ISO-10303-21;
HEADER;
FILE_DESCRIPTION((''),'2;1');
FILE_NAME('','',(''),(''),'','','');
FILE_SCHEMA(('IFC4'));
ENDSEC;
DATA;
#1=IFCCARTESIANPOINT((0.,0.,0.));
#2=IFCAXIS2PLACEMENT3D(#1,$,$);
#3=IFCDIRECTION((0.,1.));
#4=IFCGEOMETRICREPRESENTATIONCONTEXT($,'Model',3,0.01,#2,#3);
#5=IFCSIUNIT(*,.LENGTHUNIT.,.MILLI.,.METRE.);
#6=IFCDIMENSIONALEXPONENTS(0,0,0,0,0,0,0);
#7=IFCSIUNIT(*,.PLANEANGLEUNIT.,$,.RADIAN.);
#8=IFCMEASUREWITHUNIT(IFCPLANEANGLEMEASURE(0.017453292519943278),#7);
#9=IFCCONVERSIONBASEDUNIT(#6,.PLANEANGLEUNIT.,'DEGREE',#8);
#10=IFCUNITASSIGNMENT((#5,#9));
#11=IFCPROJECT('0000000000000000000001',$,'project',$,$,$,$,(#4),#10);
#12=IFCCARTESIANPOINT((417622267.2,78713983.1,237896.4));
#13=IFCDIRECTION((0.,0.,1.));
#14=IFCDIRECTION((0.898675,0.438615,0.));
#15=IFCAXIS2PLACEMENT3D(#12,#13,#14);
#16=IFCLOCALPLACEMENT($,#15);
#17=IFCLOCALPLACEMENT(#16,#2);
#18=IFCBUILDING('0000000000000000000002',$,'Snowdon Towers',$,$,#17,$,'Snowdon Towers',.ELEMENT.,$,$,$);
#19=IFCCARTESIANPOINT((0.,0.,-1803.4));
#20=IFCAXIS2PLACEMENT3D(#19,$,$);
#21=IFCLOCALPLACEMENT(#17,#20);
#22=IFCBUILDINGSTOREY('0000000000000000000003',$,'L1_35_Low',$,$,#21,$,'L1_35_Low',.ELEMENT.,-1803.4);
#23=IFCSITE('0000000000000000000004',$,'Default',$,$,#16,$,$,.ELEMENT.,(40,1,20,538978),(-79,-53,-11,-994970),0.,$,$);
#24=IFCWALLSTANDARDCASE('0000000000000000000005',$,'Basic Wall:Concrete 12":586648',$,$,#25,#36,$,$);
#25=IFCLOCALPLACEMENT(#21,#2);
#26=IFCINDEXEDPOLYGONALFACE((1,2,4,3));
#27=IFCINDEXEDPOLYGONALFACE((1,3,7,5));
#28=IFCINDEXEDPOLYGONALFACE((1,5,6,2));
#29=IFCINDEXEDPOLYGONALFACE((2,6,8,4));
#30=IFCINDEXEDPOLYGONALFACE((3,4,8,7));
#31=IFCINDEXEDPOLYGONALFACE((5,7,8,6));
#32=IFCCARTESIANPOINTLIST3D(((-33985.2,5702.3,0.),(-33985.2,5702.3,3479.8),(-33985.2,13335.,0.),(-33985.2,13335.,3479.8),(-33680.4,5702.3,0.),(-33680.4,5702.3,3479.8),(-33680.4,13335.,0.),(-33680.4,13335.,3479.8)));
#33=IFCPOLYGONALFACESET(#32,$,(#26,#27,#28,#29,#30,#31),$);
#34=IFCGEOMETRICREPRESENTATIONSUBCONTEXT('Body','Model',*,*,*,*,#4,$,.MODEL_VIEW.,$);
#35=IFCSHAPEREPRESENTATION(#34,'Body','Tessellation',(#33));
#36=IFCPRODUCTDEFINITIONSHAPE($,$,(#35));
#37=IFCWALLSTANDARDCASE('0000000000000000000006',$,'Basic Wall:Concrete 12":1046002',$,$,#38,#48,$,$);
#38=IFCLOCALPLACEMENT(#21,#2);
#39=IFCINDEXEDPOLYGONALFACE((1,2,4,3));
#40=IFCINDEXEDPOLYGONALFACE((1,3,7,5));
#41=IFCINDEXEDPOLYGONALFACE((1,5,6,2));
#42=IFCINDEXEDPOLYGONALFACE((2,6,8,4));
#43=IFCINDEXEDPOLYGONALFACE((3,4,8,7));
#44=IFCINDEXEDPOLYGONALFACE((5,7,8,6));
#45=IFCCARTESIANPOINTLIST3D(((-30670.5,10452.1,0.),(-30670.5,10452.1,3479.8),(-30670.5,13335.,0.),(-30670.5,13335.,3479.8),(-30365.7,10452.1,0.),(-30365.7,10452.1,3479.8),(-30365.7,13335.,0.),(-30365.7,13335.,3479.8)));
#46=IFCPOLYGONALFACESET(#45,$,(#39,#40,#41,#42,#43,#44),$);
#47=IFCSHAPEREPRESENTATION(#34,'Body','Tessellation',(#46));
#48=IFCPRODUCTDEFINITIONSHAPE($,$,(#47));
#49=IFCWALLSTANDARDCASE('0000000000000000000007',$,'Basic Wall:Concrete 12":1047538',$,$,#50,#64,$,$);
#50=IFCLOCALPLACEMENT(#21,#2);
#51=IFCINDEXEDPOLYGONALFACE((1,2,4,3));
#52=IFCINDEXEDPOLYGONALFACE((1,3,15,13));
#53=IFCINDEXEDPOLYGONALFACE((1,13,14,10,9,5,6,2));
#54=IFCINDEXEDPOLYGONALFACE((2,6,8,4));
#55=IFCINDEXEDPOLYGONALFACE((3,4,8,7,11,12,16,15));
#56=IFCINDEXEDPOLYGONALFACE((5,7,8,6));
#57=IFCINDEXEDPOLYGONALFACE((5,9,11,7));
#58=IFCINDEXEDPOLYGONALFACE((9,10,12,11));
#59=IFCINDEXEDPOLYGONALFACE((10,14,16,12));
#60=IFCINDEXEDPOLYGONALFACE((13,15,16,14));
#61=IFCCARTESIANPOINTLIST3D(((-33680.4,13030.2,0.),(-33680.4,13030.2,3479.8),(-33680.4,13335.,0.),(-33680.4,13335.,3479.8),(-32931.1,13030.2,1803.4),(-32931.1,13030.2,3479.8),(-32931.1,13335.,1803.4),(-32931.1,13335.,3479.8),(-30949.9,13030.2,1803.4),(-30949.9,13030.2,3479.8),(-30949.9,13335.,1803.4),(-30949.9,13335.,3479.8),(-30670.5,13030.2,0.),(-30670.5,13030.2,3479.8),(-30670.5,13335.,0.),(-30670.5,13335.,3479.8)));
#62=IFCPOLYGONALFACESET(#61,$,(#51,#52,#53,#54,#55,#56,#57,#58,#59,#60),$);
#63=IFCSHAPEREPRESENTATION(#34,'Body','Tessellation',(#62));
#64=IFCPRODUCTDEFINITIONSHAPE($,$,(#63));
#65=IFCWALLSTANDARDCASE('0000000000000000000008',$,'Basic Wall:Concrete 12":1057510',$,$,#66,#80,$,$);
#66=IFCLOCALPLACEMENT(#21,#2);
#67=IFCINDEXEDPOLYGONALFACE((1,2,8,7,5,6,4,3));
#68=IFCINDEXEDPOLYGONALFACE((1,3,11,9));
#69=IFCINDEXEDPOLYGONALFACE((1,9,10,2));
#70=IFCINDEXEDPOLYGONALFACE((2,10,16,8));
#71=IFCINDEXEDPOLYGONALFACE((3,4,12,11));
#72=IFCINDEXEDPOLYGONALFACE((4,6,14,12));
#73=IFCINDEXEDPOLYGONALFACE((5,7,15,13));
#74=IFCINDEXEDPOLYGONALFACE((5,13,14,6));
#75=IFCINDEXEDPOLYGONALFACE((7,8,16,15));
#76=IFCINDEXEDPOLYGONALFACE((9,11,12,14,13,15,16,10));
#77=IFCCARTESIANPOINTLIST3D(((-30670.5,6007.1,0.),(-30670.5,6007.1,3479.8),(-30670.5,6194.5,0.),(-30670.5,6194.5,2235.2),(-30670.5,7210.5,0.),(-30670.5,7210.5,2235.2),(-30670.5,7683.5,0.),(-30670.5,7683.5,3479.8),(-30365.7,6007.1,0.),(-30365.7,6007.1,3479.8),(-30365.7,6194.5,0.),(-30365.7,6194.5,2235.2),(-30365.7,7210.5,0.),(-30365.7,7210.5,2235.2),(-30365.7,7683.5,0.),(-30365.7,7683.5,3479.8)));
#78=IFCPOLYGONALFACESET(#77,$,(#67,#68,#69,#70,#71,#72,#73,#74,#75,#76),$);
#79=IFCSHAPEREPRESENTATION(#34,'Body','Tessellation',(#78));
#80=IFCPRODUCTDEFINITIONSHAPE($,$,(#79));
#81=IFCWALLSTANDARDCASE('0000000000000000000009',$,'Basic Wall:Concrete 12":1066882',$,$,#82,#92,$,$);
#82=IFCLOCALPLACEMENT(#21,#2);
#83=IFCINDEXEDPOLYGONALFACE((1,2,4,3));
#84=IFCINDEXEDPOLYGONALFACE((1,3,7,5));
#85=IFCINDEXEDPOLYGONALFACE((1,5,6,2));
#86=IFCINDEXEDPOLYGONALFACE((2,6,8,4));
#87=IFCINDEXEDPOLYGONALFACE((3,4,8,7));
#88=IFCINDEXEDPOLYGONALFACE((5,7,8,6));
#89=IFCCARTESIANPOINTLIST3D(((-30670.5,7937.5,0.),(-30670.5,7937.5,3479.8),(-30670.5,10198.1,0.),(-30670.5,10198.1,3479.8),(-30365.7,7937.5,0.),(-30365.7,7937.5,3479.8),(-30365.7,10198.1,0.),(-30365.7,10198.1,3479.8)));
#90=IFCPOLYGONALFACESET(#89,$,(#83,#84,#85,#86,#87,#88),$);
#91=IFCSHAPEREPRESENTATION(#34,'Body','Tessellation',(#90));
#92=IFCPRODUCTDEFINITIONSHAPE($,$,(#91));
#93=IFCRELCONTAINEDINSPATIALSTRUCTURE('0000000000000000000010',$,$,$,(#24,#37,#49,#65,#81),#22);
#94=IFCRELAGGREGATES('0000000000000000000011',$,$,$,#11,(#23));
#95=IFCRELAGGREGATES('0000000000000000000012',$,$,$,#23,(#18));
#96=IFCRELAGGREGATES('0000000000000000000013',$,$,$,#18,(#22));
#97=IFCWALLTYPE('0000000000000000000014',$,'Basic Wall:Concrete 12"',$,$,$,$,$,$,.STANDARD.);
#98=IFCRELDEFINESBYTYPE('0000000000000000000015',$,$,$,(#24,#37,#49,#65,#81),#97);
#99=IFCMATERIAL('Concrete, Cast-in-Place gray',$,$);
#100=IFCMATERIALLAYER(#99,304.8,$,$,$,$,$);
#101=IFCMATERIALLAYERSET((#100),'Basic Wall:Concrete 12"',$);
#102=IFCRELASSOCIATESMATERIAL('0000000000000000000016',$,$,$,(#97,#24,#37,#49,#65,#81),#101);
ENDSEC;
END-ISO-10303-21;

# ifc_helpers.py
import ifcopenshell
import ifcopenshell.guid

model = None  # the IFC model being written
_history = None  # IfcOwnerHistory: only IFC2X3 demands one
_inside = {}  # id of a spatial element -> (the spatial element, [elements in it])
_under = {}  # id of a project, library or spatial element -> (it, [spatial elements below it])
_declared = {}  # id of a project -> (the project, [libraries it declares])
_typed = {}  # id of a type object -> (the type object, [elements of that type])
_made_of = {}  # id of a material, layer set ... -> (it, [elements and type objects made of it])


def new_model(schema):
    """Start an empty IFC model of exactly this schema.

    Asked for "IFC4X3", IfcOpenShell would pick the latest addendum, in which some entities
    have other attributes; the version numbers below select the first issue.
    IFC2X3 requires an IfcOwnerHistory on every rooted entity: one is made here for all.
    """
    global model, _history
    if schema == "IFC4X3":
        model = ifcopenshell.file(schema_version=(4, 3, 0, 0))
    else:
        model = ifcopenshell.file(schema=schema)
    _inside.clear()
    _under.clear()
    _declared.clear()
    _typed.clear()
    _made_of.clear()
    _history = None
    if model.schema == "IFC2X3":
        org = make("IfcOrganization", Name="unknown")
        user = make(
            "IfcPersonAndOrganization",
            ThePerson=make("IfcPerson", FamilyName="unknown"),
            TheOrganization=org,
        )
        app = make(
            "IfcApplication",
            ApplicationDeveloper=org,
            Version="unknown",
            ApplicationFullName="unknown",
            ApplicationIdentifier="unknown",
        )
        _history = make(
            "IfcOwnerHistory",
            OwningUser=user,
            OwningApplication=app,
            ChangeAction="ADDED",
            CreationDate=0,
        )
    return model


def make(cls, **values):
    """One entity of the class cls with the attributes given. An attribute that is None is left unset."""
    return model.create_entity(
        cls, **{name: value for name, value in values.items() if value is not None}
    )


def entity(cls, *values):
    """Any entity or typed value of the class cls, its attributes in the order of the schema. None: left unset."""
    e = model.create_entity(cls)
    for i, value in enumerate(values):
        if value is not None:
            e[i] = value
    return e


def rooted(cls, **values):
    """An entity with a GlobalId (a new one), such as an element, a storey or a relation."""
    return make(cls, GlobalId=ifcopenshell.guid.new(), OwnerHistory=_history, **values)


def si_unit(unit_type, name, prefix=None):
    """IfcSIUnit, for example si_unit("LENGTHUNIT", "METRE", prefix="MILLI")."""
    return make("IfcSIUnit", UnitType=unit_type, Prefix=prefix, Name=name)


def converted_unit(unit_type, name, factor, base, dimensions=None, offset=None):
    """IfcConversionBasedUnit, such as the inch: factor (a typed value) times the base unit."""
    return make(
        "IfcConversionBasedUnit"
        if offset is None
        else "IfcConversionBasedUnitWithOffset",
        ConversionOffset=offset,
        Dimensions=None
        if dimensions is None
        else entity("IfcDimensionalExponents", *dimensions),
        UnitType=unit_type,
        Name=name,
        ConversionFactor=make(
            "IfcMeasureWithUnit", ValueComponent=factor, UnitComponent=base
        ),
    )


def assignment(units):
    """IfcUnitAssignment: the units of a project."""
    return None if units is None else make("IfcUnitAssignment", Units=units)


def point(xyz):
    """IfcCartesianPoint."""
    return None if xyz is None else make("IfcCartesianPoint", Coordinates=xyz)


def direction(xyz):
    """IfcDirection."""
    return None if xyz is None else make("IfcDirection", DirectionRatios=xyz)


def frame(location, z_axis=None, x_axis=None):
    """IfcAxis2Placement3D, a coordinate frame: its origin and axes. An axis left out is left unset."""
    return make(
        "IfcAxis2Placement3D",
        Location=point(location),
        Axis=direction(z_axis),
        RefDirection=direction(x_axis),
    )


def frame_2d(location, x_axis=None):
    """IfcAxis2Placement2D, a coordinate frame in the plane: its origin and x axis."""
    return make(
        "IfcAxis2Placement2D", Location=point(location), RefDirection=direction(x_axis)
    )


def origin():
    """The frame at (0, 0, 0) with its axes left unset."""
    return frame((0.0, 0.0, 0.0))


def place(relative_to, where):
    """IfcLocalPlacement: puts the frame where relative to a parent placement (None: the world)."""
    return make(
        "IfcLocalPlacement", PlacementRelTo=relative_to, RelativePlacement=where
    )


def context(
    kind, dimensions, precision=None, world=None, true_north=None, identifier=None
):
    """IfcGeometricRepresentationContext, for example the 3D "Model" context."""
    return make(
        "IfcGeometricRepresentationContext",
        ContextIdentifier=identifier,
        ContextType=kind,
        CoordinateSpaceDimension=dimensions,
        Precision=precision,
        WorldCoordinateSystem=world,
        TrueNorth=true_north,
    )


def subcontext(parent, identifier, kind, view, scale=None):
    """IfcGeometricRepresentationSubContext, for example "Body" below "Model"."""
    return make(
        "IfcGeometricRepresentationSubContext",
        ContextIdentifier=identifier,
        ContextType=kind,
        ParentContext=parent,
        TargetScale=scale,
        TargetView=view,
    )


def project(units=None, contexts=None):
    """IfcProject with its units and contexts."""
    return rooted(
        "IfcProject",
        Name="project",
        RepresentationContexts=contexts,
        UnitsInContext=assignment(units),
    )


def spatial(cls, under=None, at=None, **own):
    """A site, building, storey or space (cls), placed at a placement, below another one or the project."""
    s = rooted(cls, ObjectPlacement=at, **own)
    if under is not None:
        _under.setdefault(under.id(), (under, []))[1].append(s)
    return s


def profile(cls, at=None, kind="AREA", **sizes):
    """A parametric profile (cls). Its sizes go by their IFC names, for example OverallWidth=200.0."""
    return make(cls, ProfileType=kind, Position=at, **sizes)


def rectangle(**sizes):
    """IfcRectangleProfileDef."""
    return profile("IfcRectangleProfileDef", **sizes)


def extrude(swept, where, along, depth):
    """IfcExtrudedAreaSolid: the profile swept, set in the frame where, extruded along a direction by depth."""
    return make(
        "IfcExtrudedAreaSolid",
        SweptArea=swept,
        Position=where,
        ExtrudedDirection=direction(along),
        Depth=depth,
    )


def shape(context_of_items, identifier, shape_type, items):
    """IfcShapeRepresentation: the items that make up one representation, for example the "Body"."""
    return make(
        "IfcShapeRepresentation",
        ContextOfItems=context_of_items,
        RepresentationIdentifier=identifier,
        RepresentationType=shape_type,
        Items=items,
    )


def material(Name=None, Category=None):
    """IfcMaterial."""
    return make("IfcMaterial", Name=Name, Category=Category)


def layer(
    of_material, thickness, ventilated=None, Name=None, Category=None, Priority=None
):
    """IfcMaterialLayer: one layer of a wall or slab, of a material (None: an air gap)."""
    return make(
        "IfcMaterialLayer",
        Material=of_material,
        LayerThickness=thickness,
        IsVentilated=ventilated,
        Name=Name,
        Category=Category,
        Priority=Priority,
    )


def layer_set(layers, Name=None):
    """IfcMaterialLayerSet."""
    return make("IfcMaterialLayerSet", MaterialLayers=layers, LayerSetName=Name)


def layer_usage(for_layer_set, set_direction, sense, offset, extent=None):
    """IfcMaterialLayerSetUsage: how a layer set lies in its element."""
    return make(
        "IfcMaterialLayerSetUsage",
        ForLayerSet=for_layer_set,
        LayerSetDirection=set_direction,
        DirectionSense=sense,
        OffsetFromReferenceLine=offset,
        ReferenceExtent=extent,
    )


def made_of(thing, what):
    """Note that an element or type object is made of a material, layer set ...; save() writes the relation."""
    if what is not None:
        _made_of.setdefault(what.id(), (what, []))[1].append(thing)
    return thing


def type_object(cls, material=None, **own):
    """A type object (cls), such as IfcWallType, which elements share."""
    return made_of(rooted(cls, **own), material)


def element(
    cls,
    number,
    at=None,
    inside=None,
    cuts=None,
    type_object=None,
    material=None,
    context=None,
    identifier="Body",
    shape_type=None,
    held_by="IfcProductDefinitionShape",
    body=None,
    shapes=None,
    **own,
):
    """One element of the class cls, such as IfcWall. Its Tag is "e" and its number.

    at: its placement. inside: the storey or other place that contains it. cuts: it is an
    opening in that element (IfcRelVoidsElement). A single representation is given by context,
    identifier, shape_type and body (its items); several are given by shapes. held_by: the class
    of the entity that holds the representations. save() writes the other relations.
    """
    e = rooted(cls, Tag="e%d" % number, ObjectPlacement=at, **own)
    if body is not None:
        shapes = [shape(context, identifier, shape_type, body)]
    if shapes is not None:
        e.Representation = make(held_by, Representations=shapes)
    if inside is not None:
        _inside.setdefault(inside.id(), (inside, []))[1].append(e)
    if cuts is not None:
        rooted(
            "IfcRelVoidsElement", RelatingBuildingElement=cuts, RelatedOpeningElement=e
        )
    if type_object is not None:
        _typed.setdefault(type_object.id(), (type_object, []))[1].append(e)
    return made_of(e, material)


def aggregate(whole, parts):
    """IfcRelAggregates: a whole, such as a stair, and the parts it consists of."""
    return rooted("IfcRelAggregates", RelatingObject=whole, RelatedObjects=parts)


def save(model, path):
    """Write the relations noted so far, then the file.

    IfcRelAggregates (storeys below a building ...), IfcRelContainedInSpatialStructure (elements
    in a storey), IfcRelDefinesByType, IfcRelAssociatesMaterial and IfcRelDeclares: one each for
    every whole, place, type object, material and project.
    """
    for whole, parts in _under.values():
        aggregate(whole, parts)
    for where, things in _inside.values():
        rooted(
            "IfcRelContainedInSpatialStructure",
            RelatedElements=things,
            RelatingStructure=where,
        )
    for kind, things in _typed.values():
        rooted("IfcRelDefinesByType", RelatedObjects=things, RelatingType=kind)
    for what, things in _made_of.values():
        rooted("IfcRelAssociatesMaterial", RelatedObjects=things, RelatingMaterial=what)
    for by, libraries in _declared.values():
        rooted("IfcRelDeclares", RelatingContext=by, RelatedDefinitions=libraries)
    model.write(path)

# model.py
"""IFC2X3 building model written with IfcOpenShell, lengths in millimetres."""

from ifc_helpers import new_model, entity, si_unit, converted_unit, direction, frame, frame_2d, origin, place, context, subcontext, project, spatial, rectangle, extrude, material, layer, layer_set, layer_usage, type_object, element, save


model = new_model("IFC2X3")

# Units and contexts
model_context = context("Model", 3, precision=0.01, world=origin(), true_north=direction((0.0, 1.0)))
body_context = subcontext(model_context, "Body", "Model", "MODEL_VIEW")
ifc_project = project(units=[si_unit("LENGTHUNIT", "METRE", prefix="MILLI"), converted_unit("PLANEANGLEUNIT", "DEGREE", entity("IfcPlaneAngleMeasure", 0.017453292519943278), si_unit("PLANEANGLEUNIT", "RADIAN"), dimensions=[0, 0, 0, 0, 0, 0, 0])], contexts=[model_context])

# Site, building, storey
site_placement = place(None, frame((417622267.2, 78713983.1, 237896.4), z_axis=(0.0, 0.0, 1.0), x_axis=(0.898675, 0.438615, 0.0)))
site = spatial("IfcSite", under=ifc_project, at=site_placement, Name="Default", CompositionType="ELEMENT", RefLatitude=(40, 1, 20, 538978), RefLongitude=(-79, -53, -11, -994970), RefElevation=0.0)
building_placement = place(site_placement, origin())
building = spatial("IfcBuilding", under=site, at=building_placement, Name="Snowdon Towers", LongName="Snowdon Towers", CompositionType="ELEMENT")
storey_placement = place(building_placement, frame((0.0, 0.0, -1803.4)))
storey = spatial("IfcBuildingStorey", under=building, at=storey_placement, Name="L1_35_Low", LongName="L1_35_Low", CompositionType="ELEMENT", Elevation=-1803.4)

# Shared definitions
ifc_material_1 = material(Name="Concrete, Cast-in-Place gray")

# Walls
ifc_layer_1 = layer(ifc_material_1, 304.8)
ifc_layer_set_1 = layer_set([ifc_layer_1], Name="Basic Wall:Concrete 12\"")
wall_type_1 = type_object("IfcWallType", Name="Basic Wall:Concrete 12\"", PredefinedType="STANDARD", material=ifc_layer_set_1)
ifc_layer_usage_1 = layer_usage(ifc_layer_set_1, "AXIS2", "POSITIVE", -152.4)
wall_1_placement = place(storey_placement, frame((-33832.8, 13335.0, 0.0), z_axis=(0.0, 0.0, 1.0), x_axis=(0.0, -1.0, 0.0)))
element("IfcWallStandardCase", 1, at=wall_1_placement, inside=storey, type_object=wall_type_1, material=ifc_layer_usage_1, Name="Basic Wall:Concrete 12\":586648", context=body_context, shape_type="SweptSolid", body=[
    extrude(rectangle(XDim=7632.7, YDim=304.8, at=frame_2d((3816.4, 0.0), x_axis=(-1.0, 0.0))), origin(), (0.0, 0.0, 1.0), 3479.8),
])
ifc_layer_usage_2 = layer_usage(ifc_layer_set_1, "AXIS2", "NEGATIVE", 152.4)
wall_2_placement = place(storey_placement, frame((-30518.1, 10452.1, 0.0), z_axis=(0.0, 0.0, 1.0), x_axis=(0.0, 1.0, 0.0)))
element("IfcWallStandardCase", 2, at=wall_2_placement, inside=storey, type_object=wall_type_1, material=ifc_layer_usage_2, Name="Basic Wall:Concrete 12\":1046002", context=body_context, shape_type="SweptSolid", body=[
    extrude(rectangle(XDim=2882.9, YDim=304.8, at=frame_2d((1441.5, 0.0), x_axis=(-1.0, 0.0))), origin(), (0.0, 0.0, 1.0), 3479.8),
])

# Walls, openings
ifc_layer_usage_3 = layer_usage(ifc_layer_set_1, "AXIS2", "POSITIVE", -152.4)
wall_3_placement = place(storey_placement, frame((-30670.5, 13182.6, 0.0), z_axis=(0.0, 0.0, 1.0), x_axis=(-1.0, 0.0, 0.0)))
wall_3 = element("IfcWallStandardCase", 3, at=wall_3_placement, inside=storey, type_object=wall_type_1, material=ifc_layer_usage_3, Name="Basic Wall:Concrete 12\":1047538", context=body_context, shape_type="SweptSolid", body=[
    extrude(rectangle(XDim=3009.9, YDim=304.8, at=frame_2d((1505.0, 0.0), x_axis=(-1.0, 0.0))), origin(), (0.0, 0.0, 1.0), 3479.8),
])
opening_1_placement = place(wall_3_placement, origin())
element("IfcOpeningElement", 4, at=opening_1_placement, cuts=wall_3, ObjectType="Opening", context=body_context, shape_type="SweptSolid", body=[
    extrude(rectangle(XDim=1676.4, YDim=1981.2, at=frame_2d((0.0, 0.0), x_axis=(0.0, 1.0))), frame((1270.0, 152.4, 2641.6), z_axis=(0.0, -1.0, 0.0), x_axis=(-1.0, 0.0, 0.0)), (0.0, 0.0, 1.0), 304.8),
])
ifc_layer_usage_4 = layer_usage(ifc_layer_set_1, "AXIS2", "POSITIVE", -152.4)
wall_4_placement = place(storey_placement, frame((-30518.1, 7683.5, 0.0), z_axis=(0.0, 0.0, 1.0), x_axis=(0.0, -1.0, 0.0)))
wall_4 = element("IfcWallStandardCase", 5, at=wall_4_placement, inside=storey, type_object=wall_type_1, material=ifc_layer_usage_4, Name="Basic Wall:Concrete 12\":1057510", context=body_context, shape_type="SweptSolid", body=[
    extrude(rectangle(XDim=1676.4, YDim=304.8, at=frame_2d((838.2, 0.0), x_axis=(-1.0, 0.0))), origin(), (0.0, 0.0, 1.0), 3479.8),
])
opening_2_placement = place(wall_4_placement, origin())
element("IfcOpeningElement", 6, at=opening_2_placement, cuts=wall_4, ObjectType="Opening", context=body_context, shape_type="SweptSolid", body=[
    extrude(rectangle(XDim=2235.2, YDim=1016.0, at=frame_2d((0.0, 0.0), x_axis=(0.0, 1.0))), frame((981.0, 152.4, 1117.6), z_axis=(0.0, -1.0, 0.0), x_axis=(1.0, 0.0, 0.0)), (0.0, 0.0, 1.0), 304.8),
])

# Wall
ifc_layer_usage_5 = layer_usage(ifc_layer_set_1, "AXIS2", "POSITIVE", -152.4)
wall_5_placement = place(storey_placement, frame((-30518.1, 7937.5, 0.0), z_axis=(0.0, 0.0, 1.0), x_axis=(0.0, 1.0, 0.0)))
element("IfcWallStandardCase", 7, at=wall_5_placement, inside=storey, type_object=wall_type_1, material=ifc_layer_usage_5, Name="Basic Wall:Concrete 12\":1066882", context=body_context, shape_type="SweptSolid", body=[
    extrude(rectangle(XDim=2260.6, YDim=304.8, at=frame_2d((1130.3, 0.0), x_axis=(-1.0, 0.0))), origin(), (0.0, 0.0, 1.0), 3479.8),
])

save(model, "model.ifc")
